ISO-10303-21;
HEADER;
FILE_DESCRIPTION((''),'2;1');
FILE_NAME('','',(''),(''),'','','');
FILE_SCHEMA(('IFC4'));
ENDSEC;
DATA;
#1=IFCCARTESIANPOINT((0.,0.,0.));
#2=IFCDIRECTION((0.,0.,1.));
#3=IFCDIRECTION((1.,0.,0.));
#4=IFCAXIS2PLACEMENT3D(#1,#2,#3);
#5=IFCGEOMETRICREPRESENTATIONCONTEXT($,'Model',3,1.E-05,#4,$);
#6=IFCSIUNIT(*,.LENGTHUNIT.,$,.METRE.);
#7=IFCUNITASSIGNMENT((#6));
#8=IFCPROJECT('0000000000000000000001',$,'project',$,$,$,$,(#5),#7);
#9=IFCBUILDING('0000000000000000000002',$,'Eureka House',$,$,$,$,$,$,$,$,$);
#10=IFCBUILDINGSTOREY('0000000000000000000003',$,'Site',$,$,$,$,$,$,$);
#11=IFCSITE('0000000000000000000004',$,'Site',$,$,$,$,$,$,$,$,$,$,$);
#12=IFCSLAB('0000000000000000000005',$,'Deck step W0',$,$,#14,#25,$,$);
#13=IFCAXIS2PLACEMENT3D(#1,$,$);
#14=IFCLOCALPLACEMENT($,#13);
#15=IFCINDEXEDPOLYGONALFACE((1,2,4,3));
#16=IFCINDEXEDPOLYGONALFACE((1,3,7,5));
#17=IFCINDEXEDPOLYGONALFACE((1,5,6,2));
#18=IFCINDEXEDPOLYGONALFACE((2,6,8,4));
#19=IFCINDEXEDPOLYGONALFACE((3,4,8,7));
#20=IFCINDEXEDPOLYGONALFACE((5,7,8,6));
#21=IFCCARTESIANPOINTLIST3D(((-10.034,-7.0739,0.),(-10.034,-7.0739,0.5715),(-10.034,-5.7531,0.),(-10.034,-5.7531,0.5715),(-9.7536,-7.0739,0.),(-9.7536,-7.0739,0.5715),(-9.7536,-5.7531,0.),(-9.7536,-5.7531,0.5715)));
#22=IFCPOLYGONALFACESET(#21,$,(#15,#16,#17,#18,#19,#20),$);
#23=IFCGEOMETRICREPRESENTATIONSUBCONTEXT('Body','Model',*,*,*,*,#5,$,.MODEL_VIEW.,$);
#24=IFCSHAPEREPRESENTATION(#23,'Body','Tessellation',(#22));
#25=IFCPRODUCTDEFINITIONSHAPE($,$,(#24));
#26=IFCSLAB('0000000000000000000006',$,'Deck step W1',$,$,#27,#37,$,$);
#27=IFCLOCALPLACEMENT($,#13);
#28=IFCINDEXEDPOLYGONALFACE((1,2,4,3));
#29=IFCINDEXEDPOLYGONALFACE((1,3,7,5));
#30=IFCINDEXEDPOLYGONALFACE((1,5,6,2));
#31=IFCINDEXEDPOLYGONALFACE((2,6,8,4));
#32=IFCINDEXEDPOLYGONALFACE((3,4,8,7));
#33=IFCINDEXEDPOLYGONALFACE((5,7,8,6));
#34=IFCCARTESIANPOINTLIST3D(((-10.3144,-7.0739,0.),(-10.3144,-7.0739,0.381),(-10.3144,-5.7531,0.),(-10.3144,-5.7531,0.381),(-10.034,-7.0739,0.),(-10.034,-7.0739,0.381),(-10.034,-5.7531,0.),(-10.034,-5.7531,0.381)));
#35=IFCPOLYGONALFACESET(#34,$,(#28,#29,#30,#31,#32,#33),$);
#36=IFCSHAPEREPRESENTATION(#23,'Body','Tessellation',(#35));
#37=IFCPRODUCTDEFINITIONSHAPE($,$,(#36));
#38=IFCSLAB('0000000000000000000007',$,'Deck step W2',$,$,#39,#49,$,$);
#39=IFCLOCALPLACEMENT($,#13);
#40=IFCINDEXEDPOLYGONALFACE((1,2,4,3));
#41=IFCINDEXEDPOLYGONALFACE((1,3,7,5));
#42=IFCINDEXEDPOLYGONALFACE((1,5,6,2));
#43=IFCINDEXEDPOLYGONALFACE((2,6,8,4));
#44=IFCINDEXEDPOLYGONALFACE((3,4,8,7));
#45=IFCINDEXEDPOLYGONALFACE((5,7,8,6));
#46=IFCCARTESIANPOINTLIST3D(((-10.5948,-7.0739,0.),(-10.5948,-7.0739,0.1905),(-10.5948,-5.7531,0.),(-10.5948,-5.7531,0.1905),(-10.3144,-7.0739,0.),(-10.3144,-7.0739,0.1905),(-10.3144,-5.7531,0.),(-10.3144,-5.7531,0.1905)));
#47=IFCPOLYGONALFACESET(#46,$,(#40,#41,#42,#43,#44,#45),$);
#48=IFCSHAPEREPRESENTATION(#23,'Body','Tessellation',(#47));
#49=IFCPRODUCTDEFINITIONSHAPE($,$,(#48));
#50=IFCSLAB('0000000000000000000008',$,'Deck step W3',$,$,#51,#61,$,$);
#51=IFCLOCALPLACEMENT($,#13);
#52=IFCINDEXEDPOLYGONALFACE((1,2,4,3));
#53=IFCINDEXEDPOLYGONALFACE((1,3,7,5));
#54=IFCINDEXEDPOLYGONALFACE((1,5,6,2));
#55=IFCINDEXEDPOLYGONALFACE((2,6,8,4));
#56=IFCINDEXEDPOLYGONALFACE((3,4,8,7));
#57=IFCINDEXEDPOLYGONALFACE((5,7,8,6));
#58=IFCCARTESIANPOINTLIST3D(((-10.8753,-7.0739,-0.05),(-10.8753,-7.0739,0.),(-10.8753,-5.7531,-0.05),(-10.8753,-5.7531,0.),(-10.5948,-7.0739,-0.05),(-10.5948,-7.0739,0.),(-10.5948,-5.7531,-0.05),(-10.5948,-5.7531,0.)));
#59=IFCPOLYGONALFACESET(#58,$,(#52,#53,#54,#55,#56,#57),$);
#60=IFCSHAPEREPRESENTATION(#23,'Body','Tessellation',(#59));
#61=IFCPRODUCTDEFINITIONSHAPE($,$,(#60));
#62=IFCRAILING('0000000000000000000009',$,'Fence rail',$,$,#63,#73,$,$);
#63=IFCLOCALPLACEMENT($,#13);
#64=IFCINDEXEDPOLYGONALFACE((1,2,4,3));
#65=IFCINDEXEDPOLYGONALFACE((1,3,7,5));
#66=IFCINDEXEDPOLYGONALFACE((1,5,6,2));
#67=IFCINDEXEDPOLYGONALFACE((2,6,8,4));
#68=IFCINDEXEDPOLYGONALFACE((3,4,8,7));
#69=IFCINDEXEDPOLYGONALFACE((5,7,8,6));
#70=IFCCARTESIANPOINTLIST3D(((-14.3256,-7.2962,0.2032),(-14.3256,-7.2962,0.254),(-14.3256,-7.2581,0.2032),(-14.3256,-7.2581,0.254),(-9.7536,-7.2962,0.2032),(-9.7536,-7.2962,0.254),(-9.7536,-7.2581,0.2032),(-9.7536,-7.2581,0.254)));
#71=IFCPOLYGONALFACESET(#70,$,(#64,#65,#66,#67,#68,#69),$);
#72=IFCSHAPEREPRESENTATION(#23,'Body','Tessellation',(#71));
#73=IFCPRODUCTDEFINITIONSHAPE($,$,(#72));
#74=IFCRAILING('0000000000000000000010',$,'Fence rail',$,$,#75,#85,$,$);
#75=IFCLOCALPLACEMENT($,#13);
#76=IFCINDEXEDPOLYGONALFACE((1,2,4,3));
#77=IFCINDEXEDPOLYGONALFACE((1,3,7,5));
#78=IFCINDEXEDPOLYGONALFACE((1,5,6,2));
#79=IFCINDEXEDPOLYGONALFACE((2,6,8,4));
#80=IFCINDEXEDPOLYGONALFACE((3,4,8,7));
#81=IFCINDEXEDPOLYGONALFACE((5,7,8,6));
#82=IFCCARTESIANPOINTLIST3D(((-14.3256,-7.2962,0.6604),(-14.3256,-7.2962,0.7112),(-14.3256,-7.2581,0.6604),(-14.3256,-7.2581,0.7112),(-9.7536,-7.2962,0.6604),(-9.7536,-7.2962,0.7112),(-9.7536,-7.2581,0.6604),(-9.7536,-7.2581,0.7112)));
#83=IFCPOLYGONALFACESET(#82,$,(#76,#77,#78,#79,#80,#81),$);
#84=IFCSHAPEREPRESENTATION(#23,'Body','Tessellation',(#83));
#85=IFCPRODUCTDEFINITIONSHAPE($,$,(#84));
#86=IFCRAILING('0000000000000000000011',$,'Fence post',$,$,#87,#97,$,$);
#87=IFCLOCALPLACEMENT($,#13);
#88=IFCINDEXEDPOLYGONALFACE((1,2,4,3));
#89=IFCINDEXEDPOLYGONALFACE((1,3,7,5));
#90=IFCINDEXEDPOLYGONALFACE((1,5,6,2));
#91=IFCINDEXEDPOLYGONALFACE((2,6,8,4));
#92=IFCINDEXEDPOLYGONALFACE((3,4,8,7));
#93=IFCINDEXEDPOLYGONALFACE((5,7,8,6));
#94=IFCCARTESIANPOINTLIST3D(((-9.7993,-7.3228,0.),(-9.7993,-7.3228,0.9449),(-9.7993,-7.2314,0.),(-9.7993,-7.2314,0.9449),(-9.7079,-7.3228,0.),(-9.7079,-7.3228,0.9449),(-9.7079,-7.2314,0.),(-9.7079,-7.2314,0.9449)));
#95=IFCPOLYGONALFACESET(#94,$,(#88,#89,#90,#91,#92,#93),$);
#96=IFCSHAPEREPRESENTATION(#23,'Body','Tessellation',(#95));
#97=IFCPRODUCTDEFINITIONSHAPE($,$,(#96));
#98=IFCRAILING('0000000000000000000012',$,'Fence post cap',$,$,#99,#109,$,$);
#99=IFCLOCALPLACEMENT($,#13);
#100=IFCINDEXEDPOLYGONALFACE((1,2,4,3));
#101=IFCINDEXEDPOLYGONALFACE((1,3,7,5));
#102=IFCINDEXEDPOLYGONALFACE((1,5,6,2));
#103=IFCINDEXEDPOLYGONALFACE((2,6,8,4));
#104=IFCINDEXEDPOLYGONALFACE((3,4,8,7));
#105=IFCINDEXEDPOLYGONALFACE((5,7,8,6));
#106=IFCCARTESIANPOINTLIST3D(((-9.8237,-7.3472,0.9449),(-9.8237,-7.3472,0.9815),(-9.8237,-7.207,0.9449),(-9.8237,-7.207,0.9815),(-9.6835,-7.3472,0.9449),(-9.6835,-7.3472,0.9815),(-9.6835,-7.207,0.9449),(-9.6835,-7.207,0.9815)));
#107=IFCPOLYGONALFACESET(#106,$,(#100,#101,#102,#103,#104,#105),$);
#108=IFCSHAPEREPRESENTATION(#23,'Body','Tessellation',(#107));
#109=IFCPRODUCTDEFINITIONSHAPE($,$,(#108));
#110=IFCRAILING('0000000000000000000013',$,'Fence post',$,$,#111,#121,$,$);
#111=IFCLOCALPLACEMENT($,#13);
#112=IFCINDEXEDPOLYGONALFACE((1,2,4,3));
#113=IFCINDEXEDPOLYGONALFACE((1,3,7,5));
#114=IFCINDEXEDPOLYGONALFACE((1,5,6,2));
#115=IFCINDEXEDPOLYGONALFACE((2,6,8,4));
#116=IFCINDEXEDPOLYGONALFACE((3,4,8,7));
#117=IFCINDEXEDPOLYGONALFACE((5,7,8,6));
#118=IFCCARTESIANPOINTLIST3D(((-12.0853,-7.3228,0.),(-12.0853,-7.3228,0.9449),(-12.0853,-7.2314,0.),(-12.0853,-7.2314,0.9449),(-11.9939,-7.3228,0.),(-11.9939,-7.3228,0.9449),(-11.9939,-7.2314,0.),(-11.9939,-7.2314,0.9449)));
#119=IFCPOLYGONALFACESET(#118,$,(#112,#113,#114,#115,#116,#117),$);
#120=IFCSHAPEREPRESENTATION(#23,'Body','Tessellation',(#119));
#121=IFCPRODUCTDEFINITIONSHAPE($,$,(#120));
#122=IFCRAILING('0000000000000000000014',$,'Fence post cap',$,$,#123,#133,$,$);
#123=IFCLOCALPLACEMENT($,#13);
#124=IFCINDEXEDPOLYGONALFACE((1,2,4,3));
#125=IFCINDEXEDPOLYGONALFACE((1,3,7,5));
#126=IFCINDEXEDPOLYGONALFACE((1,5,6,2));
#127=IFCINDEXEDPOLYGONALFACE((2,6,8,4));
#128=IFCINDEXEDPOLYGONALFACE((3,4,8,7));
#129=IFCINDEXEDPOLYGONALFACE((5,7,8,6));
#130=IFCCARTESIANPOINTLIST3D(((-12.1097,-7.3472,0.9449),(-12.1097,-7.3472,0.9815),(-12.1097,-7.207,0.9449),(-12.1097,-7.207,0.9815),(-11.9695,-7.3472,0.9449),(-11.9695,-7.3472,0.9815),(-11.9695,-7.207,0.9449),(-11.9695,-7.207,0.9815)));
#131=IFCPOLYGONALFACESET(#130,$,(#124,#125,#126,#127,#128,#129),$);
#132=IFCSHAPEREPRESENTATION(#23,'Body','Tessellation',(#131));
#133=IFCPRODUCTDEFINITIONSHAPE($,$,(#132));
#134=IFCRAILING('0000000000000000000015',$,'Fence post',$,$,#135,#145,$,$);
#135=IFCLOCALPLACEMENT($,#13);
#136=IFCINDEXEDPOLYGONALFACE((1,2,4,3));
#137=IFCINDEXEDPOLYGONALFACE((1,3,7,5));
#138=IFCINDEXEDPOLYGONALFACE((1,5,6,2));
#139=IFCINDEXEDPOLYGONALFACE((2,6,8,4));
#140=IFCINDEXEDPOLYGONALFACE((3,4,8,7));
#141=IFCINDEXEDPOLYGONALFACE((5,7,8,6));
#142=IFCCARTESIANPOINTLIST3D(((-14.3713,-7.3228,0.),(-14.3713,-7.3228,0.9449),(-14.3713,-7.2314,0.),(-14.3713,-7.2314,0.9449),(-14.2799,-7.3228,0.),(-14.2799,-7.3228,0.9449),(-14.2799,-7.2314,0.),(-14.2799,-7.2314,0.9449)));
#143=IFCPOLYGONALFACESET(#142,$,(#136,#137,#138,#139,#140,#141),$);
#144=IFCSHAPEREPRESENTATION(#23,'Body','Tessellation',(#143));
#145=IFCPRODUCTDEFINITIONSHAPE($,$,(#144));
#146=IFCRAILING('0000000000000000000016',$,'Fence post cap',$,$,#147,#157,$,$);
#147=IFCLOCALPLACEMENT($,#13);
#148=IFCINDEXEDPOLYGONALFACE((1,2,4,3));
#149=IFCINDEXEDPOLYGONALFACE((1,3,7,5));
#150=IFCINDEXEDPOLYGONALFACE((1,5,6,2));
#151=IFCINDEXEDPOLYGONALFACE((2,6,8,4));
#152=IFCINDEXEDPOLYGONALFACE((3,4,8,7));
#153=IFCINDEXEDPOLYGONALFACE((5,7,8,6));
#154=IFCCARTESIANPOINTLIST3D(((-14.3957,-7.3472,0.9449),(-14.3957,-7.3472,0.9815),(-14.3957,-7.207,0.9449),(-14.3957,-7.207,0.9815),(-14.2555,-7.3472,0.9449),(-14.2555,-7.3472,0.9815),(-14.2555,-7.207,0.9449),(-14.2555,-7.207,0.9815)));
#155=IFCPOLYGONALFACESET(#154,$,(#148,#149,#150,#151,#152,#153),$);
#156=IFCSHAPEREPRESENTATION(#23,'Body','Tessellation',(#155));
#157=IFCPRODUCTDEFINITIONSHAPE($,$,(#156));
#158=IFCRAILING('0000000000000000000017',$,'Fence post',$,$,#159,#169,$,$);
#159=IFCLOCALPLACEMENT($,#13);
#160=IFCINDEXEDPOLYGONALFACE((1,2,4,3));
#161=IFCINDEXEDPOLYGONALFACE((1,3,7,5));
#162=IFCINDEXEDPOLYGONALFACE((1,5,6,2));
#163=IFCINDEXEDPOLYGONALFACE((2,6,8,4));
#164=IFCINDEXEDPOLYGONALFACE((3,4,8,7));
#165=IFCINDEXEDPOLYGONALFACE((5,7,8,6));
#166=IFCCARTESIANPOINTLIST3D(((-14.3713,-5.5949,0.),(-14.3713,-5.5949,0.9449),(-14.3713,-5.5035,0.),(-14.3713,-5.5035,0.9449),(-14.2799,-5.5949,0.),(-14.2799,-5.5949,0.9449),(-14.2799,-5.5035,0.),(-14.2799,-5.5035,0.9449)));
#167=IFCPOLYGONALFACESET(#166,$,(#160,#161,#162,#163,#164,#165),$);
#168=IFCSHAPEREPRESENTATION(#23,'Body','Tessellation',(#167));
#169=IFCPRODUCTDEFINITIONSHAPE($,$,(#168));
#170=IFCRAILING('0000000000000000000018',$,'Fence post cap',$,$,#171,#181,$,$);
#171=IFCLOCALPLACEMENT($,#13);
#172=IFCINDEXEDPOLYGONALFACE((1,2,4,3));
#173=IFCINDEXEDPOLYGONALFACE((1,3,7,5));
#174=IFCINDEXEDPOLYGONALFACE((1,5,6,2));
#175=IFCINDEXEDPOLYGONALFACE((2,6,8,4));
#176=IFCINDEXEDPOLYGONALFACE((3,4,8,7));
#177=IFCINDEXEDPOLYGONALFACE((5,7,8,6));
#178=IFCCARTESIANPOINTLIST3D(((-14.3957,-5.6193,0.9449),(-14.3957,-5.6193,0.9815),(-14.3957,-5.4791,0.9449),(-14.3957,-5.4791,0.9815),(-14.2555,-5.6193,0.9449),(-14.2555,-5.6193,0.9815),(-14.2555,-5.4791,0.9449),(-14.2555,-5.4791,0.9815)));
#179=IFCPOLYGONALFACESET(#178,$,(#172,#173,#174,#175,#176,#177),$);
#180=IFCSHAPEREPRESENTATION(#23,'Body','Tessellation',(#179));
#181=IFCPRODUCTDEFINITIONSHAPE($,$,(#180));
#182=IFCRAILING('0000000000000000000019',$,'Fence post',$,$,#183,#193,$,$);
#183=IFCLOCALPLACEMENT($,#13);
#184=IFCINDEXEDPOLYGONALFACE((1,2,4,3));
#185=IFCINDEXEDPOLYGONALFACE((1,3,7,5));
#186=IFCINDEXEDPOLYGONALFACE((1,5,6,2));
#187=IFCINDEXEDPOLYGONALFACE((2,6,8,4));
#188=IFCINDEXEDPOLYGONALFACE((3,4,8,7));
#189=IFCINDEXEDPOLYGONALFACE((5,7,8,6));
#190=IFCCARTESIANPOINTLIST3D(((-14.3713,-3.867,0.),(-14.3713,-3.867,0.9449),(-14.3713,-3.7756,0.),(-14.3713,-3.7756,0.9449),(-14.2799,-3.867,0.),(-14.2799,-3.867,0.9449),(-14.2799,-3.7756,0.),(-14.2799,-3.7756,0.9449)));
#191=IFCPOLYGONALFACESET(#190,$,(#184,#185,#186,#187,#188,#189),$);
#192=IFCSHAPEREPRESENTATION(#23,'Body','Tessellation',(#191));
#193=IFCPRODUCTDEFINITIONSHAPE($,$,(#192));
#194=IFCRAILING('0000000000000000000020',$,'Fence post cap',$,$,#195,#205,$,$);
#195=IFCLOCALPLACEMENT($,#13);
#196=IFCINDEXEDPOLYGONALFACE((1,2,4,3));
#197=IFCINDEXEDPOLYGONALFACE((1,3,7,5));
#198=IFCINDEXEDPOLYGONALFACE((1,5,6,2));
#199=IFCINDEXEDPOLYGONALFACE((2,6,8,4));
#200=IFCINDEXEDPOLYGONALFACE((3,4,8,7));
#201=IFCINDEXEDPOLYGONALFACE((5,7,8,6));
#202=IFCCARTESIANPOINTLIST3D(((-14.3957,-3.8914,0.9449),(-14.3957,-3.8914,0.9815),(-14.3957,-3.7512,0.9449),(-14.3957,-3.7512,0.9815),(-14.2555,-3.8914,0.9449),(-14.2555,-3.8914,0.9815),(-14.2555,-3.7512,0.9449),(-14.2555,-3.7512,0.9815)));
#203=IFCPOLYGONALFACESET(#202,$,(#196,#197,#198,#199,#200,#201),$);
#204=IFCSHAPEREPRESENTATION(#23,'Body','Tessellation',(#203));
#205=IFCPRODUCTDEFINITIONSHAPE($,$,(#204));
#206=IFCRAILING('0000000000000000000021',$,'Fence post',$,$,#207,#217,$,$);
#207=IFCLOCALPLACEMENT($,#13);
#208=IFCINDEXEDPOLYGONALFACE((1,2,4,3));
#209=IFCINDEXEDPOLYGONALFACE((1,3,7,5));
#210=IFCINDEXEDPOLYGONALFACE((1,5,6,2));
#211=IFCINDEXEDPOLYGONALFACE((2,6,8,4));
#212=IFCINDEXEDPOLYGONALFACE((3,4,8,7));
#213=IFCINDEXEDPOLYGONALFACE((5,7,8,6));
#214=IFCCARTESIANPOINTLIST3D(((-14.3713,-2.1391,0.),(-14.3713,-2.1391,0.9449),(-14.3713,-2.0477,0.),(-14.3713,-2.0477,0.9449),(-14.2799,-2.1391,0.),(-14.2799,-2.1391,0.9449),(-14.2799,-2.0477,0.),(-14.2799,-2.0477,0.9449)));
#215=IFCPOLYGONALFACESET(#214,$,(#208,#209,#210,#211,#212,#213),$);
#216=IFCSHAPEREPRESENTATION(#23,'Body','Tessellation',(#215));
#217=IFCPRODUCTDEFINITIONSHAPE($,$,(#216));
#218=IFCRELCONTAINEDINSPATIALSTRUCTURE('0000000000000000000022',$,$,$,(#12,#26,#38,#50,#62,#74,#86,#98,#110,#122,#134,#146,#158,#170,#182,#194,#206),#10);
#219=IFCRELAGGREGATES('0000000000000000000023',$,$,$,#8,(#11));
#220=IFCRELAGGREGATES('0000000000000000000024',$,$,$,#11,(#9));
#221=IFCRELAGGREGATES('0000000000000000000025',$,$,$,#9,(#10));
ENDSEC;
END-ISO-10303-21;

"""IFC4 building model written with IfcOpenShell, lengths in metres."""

from ifc_helpers import new_model, si_unit, frame, origin, origin_with_axes, origin_2d, place, context, subcontext, project, spatial, rectangle, extrude, element, save


model = new_model("IFC4")

# Units and contexts
model_context = context("Model", 3, precision=1e-05, world=origin_with_axes())
body_context = subcontext(model_context, "Body", "Model", "MODEL_VIEW")
ifc_project = project(units=[si_unit("LENGTHUNIT", "METRE")], contexts=[model_context])

# Site, building, storey
site = spatial("IfcSite", under=ifc_project, Name="Site")
building = spatial("IfcBuilding", under=site, Name="Eureka House")
storey = spatial("IfcBuildingStorey", under=building, Name="Site")

# Slabs
slab_1_placement = place(None, frame((-9.8938, -6.4135, 0.0), z_axis=(0.0, 0.0, 1.0), x_axis=(1.0, 0.0, 0.0)))
element("IfcSlab", 1, at=slab_1_placement, inside=storey, Name="Deck step W0", context=body_context, shape_type="SweptSolid", body=[
    extrude(rectangle(XDim=0.2804, YDim=1.3208, at=origin_2d()), origin(), (0.0, 0.0, 1.0), 0.5715),
])
slab_2_placement = place(None, frame((-10.1742, -6.4135, 0.0), z_axis=(0.0, 0.0, 1.0), x_axis=(1.0, 0.0, 0.0)))
element("IfcSlab", 2, at=slab_2_placement, inside=storey, Name="Deck step W1", context=body_context, shape_type="SweptSolid", body=[
    extrude(rectangle(XDim=0.2804, YDim=1.3208, at=origin_2d()), origin(), (0.0, 0.0, 1.0), 0.381),
])
slab_3_placement = place(None, frame((-10.4546, -6.4135, 0.0), z_axis=(0.0, 0.0, 1.0), x_axis=(1.0, 0.0, 0.0)))
element("IfcSlab", 3, at=slab_3_placement, inside=storey, Name="Deck step W2", context=body_context, shape_type="SweptSolid", body=[
    extrude(rectangle(XDim=0.2804, YDim=1.3208, at=origin_2d()), origin(), (0.0, 0.0, 1.0), 0.1905),
])
slab_4_placement = place(None, frame((-10.7351, -6.4135, -0.05), z_axis=(0.0, 0.0, 1.0), x_axis=(1.0, 0.0, 0.0)))
element("IfcSlab", 4, at=slab_4_placement, inside=storey, Name="Deck step W3", context=body_context, shape_type="SweptSolid", body=[
    extrude(rectangle(XDim=0.2804, YDim=1.3208, at=origin_2d()), origin(), (0.0, 0.0, 1.0), 0.05),
])

# Railings
for number, where, z_axis, x_axis, name in (
    (5, (-12.0396, -7.2771, 0.2032), (0.0, 0.0, 1.0), (1.0, 0.0, 0.0), "Fence rail"),
    (6, (-12.0396, -7.2771, 0.6604), (0.0, 0.0, 1.0), (1.0, 0.0, 0.0), "Fence rail"),
):
    element("IfcRailing", number, at=place(None, frame(where, z_axis=z_axis, x_axis=x_axis)), inside=storey, Name=name, context=body_context, shape_type="SweptSolid", body=[
        extrude(rectangle(XDim=4.572, YDim=0.0381, at=origin_2d()), origin(), (0.0, 0.0, 1.0), 0.0508),
    ])
railing_1_placement = place(None, frame((-9.7536, -7.2771, 0.0), z_axis=(0.0, 0.0, 1.0), x_axis=(1.0, 0.0, 0.0)))
element("IfcRailing", 7, at=railing_1_placement, inside=storey, Name="Fence post", context=body_context, shape_type="SweptSolid", body=[
    extrude(rectangle(XDim=0.0914, YDim=0.0914, at=origin_2d()), origin(), (0.0, 0.0, 1.0), 0.9449),
])
railing_2_placement = place(None, frame((-9.7536, -7.2771, 0.9449), z_axis=(0.0, 0.0, 1.0), x_axis=(1.0, 0.0, 0.0)))
element("IfcRailing", 8, at=railing_2_placement, inside=storey, Name="Fence post cap", context=body_context, shape_type="SweptSolid", body=[
    extrude(rectangle(XDim=0.1402, YDim=0.1402, at=origin_2d()), origin(), (0.0, 0.0, 1.0), 0.0366),
])
railing_3_placement = place(None, frame((-12.0396, -7.2771, 0.0), z_axis=(0.0, 0.0, 1.0), x_axis=(1.0, 0.0, 0.0)))
element("IfcRailing", 9, at=railing_3_placement, inside=storey, Name="Fence post", context=body_context, shape_type="SweptSolid", body=[
    extrude(rectangle(XDim=0.0914, YDim=0.0914, at=origin_2d()), origin(), (0.0, 0.0, 1.0), 0.9449),
])
railing_4_placement = place(None, frame((-12.0396, -7.2771, 0.9449), z_axis=(0.0, 0.0, 1.0), x_axis=(1.0, 0.0, 0.0)))
element("IfcRailing", 10, at=railing_4_placement, inside=storey, Name="Fence post cap", context=body_context, shape_type="SweptSolid", body=[
    extrude(rectangle(XDim=0.1402, YDim=0.1402, at=origin_2d()), origin(), (0.0, 0.0, 1.0), 0.0366),
])
railing_5_placement = place(None, frame((-14.3256, -7.2771, 0.0), z_axis=(0.0, 0.0, 1.0), x_axis=(1.0, 0.0, 0.0)))
element("IfcRailing", 11, at=railing_5_placement, inside=storey, Name="Fence post", context=body_context, shape_type="SweptSolid", body=[
    extrude(rectangle(XDim=0.0914, YDim=0.0914, at=origin_2d()), origin(), (0.0, 0.0, 1.0), 0.9449),
])
railing_6_placement = place(None, frame((-14.3256, -7.2771, 0.9449), z_axis=(0.0, 0.0, 1.0), x_axis=(1.0, 0.0, 0.0)))
element("IfcRailing", 12, at=railing_6_placement, inside=storey, Name="Fence post cap", context=body_context, shape_type="SweptSolid", body=[
    extrude(rectangle(XDim=0.1402, YDim=0.1402, at=origin_2d()), origin(), (0.0, 0.0, 1.0), 0.0366),
])
railing_7_placement = place(None, frame((-14.3256, -5.5492, 0.0), z_axis=(0.0, 0.0, 1.0), x_axis=(1.0, 0.0, 0.0)))
element("IfcRailing", 13, at=railing_7_placement, inside=storey, Name="Fence post", context=body_context, shape_type="SweptSolid", body=[
    extrude(rectangle(XDim=0.0914, YDim=0.0914, at=origin_2d()), origin(), (0.0, 0.0, 1.0), 0.9449),
])
railing_8_placement = place(None, frame((-14.3256, -5.5492, 0.9449), z_axis=(0.0, 0.0, 1.0), x_axis=(1.0, 0.0, 0.0)))
element("IfcRailing", 14, at=railing_8_placement, inside=storey, Name="Fence post cap", context=body_context, shape_type="SweptSolid", body=[
    extrude(rectangle(XDim=0.1402, YDim=0.1402, at=origin_2d()), origin(), (0.0, 0.0, 1.0), 0.0366),
])
railing_9_placement = place(None, frame((-14.3256, -3.8213, 0.0), z_axis=(0.0, 0.0, 1.0), x_axis=(1.0, 0.0, 0.0)))
element("IfcRailing", 15, at=railing_9_placement, inside=storey, Name="Fence post", context=body_context, shape_type="SweptSolid", body=[
    extrude(rectangle(XDim=0.0914, YDim=0.0914, at=origin_2d()), origin(), (0.0, 0.0, 1.0), 0.9449),
])
railing_10_placement = place(None, frame((-14.3256, -3.8213, 0.9449), z_axis=(0.0, 0.0, 1.0), x_axis=(1.0, 0.0, 0.0)))
element("IfcRailing", 16, at=railing_10_placement, inside=storey, Name="Fence post cap", context=body_context, shape_type="SweptSolid", body=[
    extrude(rectangle(XDim=0.1402, YDim=0.1402, at=origin_2d()), origin(), (0.0, 0.0, 1.0), 0.0366),
])
railing_11_placement = place(None, frame((-14.3256, -2.0934, 0.0), z_axis=(0.0, 0.0, 1.0), x_axis=(1.0, 0.0, 0.0)))
element("IfcRailing", 17, at=railing_11_placement, inside=storey, Name="Fence post", context=body_context, shape_type="SweptSolid", body=[
    extrude(rectangle(XDim=0.0914, YDim=0.0914, at=origin_2d()), origin(), (0.0, 0.0, 1.0), 0.9449),
])

save(model, "model.ifc")
